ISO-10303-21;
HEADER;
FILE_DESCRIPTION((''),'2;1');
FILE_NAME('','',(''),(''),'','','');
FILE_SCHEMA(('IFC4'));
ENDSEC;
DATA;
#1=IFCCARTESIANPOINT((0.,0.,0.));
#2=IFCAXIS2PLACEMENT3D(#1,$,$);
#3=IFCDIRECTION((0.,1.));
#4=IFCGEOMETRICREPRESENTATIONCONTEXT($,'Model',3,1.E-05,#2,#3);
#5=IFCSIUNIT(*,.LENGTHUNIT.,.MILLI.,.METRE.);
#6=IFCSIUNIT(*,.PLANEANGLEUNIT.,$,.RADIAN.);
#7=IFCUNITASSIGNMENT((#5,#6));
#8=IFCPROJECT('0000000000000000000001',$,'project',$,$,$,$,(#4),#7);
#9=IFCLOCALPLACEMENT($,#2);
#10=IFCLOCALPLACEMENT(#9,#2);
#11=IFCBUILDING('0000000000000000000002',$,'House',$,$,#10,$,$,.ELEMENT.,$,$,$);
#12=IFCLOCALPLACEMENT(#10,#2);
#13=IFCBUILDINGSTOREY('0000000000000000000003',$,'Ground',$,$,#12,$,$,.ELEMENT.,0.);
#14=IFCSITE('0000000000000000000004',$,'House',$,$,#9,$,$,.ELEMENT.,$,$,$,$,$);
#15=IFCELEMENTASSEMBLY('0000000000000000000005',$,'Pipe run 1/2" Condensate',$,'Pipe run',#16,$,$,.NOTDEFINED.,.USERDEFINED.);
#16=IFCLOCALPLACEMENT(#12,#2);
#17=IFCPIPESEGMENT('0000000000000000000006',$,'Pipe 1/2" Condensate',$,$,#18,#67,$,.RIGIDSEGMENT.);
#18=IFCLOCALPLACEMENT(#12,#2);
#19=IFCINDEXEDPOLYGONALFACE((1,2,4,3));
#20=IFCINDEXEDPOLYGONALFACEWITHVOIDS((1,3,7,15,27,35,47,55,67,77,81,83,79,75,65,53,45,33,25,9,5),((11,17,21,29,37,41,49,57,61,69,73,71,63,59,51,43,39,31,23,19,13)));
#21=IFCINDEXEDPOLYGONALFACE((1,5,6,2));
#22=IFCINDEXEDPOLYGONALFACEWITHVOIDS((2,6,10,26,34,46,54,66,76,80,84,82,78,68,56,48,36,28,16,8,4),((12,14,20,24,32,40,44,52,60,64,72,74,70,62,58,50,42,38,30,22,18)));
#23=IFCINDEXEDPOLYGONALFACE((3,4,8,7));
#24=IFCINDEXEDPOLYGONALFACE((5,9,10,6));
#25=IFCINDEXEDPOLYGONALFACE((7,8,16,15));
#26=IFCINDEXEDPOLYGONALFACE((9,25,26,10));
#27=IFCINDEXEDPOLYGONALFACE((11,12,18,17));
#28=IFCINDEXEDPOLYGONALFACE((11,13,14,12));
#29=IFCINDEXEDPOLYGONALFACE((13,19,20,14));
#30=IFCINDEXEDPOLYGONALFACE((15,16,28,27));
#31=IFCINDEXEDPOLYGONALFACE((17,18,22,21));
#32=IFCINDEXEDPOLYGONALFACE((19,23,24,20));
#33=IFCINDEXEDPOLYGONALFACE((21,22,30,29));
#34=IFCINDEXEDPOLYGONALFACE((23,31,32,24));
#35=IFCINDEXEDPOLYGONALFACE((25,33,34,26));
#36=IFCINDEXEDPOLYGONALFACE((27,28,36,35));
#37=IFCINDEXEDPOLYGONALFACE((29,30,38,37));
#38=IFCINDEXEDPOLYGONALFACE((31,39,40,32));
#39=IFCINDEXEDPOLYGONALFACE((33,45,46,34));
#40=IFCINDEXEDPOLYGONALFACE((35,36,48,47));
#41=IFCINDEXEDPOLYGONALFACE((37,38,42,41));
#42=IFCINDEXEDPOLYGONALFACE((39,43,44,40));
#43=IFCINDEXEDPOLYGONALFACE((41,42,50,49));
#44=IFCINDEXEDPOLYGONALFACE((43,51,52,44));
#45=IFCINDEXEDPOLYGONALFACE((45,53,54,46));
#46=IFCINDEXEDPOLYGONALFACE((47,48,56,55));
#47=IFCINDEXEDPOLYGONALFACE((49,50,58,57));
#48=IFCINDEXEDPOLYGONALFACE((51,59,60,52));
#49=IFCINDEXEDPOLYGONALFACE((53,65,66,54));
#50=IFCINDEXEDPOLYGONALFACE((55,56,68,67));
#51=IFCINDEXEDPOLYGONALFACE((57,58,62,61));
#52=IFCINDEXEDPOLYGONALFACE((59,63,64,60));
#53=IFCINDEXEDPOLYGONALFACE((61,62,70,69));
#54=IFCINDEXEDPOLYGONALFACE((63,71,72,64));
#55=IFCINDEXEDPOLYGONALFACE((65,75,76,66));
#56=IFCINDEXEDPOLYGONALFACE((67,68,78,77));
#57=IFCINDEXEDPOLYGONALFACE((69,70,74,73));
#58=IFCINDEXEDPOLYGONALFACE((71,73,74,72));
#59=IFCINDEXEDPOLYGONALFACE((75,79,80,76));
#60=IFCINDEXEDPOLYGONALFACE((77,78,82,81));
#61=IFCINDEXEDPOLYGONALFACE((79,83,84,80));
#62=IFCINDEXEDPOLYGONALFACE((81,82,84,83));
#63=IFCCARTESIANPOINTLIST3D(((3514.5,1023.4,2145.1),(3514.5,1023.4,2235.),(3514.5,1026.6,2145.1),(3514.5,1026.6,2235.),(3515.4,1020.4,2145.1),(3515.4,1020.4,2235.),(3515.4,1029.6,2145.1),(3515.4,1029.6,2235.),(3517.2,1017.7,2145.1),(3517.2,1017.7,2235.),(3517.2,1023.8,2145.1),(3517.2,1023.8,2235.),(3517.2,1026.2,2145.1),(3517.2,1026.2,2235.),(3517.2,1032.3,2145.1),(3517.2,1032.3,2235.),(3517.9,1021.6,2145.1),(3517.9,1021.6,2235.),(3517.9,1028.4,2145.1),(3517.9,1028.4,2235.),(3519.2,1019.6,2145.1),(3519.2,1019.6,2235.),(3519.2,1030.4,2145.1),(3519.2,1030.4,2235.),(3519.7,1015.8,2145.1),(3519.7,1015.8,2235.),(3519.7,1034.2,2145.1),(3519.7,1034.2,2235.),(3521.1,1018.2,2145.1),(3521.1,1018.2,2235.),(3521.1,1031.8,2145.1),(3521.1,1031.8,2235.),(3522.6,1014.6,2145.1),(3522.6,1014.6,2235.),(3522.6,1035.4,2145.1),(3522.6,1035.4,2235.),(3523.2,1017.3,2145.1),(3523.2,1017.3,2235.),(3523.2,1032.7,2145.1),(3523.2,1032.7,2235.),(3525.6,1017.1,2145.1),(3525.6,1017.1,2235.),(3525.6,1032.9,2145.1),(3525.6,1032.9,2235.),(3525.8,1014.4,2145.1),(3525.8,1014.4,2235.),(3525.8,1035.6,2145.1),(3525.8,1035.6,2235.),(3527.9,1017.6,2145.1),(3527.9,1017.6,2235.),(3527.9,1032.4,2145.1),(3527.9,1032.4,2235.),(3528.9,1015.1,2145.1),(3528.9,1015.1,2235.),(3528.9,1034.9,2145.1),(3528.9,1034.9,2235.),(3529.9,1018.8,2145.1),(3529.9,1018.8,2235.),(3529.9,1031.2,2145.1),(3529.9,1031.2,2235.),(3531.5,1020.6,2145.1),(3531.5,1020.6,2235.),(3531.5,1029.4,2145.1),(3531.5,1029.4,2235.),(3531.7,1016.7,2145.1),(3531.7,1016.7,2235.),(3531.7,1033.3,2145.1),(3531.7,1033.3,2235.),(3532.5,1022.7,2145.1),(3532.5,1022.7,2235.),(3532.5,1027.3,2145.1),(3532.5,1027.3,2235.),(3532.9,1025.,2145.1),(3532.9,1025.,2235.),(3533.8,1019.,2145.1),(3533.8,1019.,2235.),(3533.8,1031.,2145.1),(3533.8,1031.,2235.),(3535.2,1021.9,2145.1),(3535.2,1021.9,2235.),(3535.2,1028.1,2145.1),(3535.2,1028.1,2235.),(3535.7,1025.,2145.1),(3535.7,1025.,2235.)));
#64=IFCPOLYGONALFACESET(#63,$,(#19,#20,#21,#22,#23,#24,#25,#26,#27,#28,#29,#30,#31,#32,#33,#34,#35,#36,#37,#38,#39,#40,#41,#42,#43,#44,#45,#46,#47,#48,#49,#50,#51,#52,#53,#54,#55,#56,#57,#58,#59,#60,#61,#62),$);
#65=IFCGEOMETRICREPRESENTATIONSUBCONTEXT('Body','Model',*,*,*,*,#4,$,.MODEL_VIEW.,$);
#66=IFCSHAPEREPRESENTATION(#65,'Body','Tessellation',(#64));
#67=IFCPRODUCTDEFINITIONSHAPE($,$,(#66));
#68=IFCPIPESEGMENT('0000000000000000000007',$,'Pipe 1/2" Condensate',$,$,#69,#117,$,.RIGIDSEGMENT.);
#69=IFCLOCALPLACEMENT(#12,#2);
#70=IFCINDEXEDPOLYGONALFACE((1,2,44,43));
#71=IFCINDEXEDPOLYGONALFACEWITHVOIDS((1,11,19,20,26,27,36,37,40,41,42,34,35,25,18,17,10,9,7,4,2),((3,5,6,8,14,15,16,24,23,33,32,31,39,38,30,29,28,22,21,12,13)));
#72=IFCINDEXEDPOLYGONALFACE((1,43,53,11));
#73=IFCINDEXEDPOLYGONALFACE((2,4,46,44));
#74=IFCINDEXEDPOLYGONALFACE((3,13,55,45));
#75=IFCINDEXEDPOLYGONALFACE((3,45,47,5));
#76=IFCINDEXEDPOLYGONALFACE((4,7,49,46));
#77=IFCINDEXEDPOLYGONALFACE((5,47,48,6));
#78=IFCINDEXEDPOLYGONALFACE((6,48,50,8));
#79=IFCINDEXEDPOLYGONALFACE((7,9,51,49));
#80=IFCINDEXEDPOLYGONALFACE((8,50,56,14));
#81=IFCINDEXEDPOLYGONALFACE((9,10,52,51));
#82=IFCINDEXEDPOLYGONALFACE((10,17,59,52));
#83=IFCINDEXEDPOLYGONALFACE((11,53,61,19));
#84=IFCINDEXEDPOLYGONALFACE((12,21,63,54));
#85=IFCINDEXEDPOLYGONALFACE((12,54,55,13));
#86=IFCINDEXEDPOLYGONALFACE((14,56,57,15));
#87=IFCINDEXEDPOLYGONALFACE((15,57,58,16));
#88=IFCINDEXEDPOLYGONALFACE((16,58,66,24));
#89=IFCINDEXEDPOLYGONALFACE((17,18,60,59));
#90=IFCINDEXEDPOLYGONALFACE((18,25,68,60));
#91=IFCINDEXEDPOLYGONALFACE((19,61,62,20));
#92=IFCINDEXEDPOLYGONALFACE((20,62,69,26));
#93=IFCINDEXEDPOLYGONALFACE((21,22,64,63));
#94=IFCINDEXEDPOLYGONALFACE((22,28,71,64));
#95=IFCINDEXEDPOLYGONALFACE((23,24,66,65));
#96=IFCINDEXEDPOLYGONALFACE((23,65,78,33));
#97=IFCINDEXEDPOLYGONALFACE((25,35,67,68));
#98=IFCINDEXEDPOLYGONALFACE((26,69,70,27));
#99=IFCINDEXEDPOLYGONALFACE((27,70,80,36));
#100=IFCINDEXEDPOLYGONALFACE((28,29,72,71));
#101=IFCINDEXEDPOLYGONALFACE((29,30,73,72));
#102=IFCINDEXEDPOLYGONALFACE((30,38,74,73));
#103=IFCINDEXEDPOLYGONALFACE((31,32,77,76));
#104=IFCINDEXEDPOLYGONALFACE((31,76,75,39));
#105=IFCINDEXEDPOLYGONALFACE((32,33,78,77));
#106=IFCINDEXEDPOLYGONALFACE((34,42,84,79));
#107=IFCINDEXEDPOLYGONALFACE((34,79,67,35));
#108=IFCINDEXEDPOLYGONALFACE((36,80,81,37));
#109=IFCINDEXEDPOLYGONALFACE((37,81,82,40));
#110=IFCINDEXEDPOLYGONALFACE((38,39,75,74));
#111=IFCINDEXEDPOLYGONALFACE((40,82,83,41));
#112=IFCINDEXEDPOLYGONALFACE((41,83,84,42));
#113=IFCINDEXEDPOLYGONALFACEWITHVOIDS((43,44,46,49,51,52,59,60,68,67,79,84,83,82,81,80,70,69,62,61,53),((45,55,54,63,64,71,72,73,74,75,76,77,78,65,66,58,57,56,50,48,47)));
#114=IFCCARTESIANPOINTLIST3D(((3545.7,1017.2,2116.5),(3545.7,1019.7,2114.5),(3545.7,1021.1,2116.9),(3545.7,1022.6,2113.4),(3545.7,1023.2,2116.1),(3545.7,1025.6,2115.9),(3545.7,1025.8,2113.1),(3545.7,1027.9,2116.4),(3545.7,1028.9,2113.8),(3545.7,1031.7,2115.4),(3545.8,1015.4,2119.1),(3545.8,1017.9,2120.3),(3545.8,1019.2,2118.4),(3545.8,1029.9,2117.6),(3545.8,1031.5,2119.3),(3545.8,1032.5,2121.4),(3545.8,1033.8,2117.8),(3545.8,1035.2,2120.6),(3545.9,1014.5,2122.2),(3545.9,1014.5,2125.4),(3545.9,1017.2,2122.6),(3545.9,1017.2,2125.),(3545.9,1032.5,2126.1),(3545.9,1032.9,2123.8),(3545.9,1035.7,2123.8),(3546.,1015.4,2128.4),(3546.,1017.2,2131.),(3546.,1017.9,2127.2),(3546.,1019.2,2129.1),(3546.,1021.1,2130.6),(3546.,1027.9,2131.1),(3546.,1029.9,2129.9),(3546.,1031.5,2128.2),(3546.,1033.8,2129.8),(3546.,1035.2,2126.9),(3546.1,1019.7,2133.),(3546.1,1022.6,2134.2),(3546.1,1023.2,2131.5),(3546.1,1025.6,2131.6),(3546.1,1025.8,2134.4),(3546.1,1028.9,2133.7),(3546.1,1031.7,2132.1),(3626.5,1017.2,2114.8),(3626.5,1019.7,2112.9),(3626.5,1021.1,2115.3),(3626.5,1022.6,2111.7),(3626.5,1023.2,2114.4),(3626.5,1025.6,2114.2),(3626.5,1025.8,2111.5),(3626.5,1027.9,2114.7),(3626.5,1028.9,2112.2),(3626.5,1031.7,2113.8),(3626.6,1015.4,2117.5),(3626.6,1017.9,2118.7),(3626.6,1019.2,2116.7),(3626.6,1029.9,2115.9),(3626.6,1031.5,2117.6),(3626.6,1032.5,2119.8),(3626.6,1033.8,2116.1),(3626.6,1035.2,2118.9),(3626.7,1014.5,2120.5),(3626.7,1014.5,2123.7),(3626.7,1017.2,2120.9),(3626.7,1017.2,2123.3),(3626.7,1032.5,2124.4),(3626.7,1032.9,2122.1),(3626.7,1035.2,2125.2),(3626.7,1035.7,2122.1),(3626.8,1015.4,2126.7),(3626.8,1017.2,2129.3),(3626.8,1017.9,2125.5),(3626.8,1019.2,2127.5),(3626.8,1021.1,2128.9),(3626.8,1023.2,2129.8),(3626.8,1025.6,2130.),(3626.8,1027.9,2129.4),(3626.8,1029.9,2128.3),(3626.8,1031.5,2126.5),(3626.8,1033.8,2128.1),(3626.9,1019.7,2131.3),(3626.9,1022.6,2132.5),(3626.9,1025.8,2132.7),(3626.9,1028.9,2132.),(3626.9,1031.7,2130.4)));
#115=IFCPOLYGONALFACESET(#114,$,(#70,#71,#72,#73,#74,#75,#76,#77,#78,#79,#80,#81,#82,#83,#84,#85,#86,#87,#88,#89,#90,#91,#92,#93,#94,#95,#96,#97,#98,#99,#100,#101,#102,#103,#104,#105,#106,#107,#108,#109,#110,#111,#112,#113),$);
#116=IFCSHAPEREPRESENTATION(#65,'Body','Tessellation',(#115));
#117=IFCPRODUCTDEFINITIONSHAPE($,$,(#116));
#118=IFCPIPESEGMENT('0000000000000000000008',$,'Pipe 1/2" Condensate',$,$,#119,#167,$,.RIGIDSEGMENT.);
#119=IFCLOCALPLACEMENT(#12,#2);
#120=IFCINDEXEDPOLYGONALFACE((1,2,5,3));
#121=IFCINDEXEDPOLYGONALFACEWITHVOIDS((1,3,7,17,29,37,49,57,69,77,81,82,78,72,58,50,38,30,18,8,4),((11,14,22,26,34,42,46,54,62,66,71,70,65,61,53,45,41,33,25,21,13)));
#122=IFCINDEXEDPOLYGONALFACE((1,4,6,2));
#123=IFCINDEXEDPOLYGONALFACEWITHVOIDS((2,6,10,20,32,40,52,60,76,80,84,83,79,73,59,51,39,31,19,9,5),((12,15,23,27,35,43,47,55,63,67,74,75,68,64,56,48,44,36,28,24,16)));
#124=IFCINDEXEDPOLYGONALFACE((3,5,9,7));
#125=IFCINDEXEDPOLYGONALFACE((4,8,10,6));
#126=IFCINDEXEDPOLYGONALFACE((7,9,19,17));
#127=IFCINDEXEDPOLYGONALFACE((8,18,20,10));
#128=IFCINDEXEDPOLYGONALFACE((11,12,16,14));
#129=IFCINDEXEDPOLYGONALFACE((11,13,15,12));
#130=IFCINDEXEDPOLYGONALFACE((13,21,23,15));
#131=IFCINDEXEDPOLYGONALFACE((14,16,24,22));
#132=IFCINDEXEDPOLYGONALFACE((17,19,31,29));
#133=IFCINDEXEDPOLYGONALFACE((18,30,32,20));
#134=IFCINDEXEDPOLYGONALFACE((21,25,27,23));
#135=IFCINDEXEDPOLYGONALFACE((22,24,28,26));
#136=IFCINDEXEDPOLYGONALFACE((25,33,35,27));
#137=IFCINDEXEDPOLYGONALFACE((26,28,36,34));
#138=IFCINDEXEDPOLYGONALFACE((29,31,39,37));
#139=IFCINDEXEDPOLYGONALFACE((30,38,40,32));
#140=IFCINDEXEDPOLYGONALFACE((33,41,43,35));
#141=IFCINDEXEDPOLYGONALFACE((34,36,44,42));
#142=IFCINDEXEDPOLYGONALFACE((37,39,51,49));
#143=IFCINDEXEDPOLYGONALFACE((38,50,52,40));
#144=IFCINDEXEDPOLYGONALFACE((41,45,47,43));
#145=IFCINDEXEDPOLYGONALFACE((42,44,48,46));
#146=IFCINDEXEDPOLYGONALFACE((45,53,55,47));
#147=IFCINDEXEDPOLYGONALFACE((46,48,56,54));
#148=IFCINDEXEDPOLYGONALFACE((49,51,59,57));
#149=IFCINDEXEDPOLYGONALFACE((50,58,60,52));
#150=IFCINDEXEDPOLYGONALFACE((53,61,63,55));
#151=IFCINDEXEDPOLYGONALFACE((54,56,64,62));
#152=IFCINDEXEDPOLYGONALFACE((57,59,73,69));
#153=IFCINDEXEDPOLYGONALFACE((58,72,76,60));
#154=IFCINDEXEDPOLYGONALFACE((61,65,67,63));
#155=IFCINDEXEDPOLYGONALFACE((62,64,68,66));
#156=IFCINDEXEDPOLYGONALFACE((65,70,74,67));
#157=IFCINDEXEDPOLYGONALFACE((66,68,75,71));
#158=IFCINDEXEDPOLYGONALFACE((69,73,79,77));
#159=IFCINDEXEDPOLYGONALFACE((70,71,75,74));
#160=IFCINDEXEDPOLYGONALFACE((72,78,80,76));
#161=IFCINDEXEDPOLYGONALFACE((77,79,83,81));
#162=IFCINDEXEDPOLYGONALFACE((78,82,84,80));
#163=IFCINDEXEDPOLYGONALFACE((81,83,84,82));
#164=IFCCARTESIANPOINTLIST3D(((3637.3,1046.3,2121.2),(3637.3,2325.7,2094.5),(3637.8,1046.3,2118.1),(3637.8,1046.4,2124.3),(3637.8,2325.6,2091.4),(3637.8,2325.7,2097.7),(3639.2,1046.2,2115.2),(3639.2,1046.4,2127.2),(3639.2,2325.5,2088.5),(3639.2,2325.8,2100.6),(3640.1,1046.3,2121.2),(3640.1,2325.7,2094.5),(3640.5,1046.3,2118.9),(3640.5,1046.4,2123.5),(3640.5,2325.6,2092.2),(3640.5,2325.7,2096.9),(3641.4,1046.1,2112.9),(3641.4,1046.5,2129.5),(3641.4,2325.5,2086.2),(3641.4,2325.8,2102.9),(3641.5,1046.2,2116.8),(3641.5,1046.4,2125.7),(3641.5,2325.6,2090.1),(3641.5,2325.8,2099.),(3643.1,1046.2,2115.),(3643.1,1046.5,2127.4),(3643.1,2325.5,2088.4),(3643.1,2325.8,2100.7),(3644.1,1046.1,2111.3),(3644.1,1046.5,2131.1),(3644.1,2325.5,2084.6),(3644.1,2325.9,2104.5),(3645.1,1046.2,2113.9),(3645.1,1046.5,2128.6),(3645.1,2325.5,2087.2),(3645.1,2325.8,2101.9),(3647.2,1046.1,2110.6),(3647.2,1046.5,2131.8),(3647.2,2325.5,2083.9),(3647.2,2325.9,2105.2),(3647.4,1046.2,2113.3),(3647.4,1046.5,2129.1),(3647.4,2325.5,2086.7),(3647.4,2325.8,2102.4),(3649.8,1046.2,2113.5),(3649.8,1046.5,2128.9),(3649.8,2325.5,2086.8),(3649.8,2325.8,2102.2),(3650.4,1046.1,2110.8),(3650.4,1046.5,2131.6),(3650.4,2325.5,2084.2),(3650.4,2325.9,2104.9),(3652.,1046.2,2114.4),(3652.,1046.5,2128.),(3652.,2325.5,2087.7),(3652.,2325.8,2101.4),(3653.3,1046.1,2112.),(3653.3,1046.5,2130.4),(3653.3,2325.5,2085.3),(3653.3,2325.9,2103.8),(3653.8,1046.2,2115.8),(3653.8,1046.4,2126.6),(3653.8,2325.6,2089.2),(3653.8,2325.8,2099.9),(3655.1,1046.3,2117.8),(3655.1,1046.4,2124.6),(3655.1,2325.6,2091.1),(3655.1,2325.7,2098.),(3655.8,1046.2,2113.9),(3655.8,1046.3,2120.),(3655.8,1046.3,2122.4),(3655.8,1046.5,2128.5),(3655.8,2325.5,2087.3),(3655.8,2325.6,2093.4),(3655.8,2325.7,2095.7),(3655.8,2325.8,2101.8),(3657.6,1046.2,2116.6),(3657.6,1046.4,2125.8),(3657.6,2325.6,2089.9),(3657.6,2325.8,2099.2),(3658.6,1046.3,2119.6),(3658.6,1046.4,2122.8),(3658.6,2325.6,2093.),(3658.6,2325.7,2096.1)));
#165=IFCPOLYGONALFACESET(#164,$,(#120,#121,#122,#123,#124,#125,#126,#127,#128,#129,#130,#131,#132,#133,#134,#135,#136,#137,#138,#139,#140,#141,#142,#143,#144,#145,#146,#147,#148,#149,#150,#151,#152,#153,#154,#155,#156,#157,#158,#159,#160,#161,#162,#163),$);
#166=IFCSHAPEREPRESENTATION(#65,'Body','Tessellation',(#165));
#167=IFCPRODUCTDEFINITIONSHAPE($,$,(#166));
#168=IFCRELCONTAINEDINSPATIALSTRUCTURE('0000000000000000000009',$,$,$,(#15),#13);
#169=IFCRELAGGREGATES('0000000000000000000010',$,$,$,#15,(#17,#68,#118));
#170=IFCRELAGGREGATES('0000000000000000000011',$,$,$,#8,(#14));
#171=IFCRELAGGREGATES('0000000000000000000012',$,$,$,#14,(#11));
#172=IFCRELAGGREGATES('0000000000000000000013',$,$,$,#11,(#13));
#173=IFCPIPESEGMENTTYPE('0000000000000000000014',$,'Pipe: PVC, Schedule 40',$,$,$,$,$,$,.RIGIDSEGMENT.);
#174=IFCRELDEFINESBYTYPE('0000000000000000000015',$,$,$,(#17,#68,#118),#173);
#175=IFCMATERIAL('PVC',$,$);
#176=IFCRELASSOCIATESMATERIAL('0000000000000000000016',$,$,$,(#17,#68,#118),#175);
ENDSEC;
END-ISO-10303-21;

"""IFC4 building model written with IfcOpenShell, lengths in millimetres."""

from ifc_helpers import new_model, si_unit, direction, frame, origin, origin_with_axes, origin_2d, place, context, subcontext, project, spatial, hollow_circle, extrude, material, type_object, element, aggregate, save


model = new_model("IFC4")

# Units and contexts
model_context = context("Model", 3, precision=1e-05, world=origin(), true_north=direction((0.0, 1.0)))
body_context = subcontext(model_context, "Body", "Model", "MODEL_VIEW")
ifc_project = project(units=[si_unit("LENGTHUNIT", "METRE", prefix="MILLI"), si_unit("PLANEANGLEUNIT", "RADIAN")], contexts=[model_context])

# Site, building, storey
site_placement = place(None, origin())
site = spatial("IfcSite", under=ifc_project, at=site_placement, Name="House", CompositionType="ELEMENT")
building_placement = place(site_placement, origin())
building = spatial("IfcBuilding", under=site, at=building_placement, Name="House", CompositionType="ELEMENT")
storey_placement = place(building_placement, origin())
storey = spatial("IfcBuildingStorey", under=building, at=storey_placement, Name="Ground", CompositionType="ELEMENT", Elevation=0.0)

# Element assembly
assembly_1_placement = place(storey_placement, origin_with_axes())
assembly_1 = element("IfcElementAssembly", 1, at=assembly_1_placement, inside=storey, Name="Pipe run 1/2\" Condensate", ObjectType="Pipe run", AssemblyPlace="NOTDEFINED", PredefinedType="USERDEFINED")
ifc_material_1 = material(Name="PVC")

# Pipe segments
pipe_segment_type_1 = type_object("IfcPipeSegmentType", Name="Pipe: PVC, Schedule 40", PredefinedType="RIGIDSEGMENT")
pipe_segment_1_placement = place(storey_placement, origin_with_axes())
pipe_segment_1 = element("IfcPipeSegment", 2, at=pipe_segment_1_placement, type_object=pipe_segment_type_1, material=ifc_material_1, Name="Pipe 1/2\" Condensate", PredefinedType="RIGIDSEGMENT", context=body_context, shape_type="SweptSolid", body=[
    extrude(hollow_circle(Radius=10.7, WallThickness=2.8, at=origin_2d()), frame((3525.0, 1025.0, 2235.0), z_axis=(0.0, 0.0, -1.0), x_axis=(1.0, 0.0, 0.0)), (0.0, 0.0, 1.0), 89.9),
])
pipe_segment_2_placement = place(storey_placement, origin_with_axes())
pipe_segment_2 = element("IfcPipeSegment", 3, at=pipe_segment_2_placement, type_object=pipe_segment_type_1, material=ifc_material_1, Name="Pipe 1/2\" Condensate", PredefinedType="RIGIDSEGMENT", context=body_context, shape_type="SweptSolid", body=[
    extrude(hollow_circle(Radius=10.7, WallThickness=2.8, at=origin_2d()), frame((3545.9, 1025.0, 2123.8), z_axis=(0.999783, 0.0, -0.020829), x_axis=(0.0, 1.0, 0.0)), (0.0, 0.0, 1.0), 80.8),
])
pipe_segment_3_placement = place(storey_placement, origin_with_axes())
pipe_segment_3 = element("IfcPipeSegment", 4, at=pipe_segment_3_placement, type_object=pipe_segment_type_1, material=ifc_material_1, Name="Pipe 1/2\" Condensate", PredefinedType="RIGIDSEGMENT", context=body_context, shape_type="SweptSolid", body=[
    extrude(hollow_circle(Radius=10.7, WallThickness=2.8, at=origin_2d()), frame((3648.0, 1046.3, 2121.2), z_axis=(0.0, 0.999783, -0.020829), x_axis=(-1.0, 0.0, 0.0)), (0.0, 0.0, 1.0), 1279.6),
])
aggregate(assembly_1, [pipe_segment_1, pipe_segment_2, pipe_segment_3])

save(model, "model.ifc")
